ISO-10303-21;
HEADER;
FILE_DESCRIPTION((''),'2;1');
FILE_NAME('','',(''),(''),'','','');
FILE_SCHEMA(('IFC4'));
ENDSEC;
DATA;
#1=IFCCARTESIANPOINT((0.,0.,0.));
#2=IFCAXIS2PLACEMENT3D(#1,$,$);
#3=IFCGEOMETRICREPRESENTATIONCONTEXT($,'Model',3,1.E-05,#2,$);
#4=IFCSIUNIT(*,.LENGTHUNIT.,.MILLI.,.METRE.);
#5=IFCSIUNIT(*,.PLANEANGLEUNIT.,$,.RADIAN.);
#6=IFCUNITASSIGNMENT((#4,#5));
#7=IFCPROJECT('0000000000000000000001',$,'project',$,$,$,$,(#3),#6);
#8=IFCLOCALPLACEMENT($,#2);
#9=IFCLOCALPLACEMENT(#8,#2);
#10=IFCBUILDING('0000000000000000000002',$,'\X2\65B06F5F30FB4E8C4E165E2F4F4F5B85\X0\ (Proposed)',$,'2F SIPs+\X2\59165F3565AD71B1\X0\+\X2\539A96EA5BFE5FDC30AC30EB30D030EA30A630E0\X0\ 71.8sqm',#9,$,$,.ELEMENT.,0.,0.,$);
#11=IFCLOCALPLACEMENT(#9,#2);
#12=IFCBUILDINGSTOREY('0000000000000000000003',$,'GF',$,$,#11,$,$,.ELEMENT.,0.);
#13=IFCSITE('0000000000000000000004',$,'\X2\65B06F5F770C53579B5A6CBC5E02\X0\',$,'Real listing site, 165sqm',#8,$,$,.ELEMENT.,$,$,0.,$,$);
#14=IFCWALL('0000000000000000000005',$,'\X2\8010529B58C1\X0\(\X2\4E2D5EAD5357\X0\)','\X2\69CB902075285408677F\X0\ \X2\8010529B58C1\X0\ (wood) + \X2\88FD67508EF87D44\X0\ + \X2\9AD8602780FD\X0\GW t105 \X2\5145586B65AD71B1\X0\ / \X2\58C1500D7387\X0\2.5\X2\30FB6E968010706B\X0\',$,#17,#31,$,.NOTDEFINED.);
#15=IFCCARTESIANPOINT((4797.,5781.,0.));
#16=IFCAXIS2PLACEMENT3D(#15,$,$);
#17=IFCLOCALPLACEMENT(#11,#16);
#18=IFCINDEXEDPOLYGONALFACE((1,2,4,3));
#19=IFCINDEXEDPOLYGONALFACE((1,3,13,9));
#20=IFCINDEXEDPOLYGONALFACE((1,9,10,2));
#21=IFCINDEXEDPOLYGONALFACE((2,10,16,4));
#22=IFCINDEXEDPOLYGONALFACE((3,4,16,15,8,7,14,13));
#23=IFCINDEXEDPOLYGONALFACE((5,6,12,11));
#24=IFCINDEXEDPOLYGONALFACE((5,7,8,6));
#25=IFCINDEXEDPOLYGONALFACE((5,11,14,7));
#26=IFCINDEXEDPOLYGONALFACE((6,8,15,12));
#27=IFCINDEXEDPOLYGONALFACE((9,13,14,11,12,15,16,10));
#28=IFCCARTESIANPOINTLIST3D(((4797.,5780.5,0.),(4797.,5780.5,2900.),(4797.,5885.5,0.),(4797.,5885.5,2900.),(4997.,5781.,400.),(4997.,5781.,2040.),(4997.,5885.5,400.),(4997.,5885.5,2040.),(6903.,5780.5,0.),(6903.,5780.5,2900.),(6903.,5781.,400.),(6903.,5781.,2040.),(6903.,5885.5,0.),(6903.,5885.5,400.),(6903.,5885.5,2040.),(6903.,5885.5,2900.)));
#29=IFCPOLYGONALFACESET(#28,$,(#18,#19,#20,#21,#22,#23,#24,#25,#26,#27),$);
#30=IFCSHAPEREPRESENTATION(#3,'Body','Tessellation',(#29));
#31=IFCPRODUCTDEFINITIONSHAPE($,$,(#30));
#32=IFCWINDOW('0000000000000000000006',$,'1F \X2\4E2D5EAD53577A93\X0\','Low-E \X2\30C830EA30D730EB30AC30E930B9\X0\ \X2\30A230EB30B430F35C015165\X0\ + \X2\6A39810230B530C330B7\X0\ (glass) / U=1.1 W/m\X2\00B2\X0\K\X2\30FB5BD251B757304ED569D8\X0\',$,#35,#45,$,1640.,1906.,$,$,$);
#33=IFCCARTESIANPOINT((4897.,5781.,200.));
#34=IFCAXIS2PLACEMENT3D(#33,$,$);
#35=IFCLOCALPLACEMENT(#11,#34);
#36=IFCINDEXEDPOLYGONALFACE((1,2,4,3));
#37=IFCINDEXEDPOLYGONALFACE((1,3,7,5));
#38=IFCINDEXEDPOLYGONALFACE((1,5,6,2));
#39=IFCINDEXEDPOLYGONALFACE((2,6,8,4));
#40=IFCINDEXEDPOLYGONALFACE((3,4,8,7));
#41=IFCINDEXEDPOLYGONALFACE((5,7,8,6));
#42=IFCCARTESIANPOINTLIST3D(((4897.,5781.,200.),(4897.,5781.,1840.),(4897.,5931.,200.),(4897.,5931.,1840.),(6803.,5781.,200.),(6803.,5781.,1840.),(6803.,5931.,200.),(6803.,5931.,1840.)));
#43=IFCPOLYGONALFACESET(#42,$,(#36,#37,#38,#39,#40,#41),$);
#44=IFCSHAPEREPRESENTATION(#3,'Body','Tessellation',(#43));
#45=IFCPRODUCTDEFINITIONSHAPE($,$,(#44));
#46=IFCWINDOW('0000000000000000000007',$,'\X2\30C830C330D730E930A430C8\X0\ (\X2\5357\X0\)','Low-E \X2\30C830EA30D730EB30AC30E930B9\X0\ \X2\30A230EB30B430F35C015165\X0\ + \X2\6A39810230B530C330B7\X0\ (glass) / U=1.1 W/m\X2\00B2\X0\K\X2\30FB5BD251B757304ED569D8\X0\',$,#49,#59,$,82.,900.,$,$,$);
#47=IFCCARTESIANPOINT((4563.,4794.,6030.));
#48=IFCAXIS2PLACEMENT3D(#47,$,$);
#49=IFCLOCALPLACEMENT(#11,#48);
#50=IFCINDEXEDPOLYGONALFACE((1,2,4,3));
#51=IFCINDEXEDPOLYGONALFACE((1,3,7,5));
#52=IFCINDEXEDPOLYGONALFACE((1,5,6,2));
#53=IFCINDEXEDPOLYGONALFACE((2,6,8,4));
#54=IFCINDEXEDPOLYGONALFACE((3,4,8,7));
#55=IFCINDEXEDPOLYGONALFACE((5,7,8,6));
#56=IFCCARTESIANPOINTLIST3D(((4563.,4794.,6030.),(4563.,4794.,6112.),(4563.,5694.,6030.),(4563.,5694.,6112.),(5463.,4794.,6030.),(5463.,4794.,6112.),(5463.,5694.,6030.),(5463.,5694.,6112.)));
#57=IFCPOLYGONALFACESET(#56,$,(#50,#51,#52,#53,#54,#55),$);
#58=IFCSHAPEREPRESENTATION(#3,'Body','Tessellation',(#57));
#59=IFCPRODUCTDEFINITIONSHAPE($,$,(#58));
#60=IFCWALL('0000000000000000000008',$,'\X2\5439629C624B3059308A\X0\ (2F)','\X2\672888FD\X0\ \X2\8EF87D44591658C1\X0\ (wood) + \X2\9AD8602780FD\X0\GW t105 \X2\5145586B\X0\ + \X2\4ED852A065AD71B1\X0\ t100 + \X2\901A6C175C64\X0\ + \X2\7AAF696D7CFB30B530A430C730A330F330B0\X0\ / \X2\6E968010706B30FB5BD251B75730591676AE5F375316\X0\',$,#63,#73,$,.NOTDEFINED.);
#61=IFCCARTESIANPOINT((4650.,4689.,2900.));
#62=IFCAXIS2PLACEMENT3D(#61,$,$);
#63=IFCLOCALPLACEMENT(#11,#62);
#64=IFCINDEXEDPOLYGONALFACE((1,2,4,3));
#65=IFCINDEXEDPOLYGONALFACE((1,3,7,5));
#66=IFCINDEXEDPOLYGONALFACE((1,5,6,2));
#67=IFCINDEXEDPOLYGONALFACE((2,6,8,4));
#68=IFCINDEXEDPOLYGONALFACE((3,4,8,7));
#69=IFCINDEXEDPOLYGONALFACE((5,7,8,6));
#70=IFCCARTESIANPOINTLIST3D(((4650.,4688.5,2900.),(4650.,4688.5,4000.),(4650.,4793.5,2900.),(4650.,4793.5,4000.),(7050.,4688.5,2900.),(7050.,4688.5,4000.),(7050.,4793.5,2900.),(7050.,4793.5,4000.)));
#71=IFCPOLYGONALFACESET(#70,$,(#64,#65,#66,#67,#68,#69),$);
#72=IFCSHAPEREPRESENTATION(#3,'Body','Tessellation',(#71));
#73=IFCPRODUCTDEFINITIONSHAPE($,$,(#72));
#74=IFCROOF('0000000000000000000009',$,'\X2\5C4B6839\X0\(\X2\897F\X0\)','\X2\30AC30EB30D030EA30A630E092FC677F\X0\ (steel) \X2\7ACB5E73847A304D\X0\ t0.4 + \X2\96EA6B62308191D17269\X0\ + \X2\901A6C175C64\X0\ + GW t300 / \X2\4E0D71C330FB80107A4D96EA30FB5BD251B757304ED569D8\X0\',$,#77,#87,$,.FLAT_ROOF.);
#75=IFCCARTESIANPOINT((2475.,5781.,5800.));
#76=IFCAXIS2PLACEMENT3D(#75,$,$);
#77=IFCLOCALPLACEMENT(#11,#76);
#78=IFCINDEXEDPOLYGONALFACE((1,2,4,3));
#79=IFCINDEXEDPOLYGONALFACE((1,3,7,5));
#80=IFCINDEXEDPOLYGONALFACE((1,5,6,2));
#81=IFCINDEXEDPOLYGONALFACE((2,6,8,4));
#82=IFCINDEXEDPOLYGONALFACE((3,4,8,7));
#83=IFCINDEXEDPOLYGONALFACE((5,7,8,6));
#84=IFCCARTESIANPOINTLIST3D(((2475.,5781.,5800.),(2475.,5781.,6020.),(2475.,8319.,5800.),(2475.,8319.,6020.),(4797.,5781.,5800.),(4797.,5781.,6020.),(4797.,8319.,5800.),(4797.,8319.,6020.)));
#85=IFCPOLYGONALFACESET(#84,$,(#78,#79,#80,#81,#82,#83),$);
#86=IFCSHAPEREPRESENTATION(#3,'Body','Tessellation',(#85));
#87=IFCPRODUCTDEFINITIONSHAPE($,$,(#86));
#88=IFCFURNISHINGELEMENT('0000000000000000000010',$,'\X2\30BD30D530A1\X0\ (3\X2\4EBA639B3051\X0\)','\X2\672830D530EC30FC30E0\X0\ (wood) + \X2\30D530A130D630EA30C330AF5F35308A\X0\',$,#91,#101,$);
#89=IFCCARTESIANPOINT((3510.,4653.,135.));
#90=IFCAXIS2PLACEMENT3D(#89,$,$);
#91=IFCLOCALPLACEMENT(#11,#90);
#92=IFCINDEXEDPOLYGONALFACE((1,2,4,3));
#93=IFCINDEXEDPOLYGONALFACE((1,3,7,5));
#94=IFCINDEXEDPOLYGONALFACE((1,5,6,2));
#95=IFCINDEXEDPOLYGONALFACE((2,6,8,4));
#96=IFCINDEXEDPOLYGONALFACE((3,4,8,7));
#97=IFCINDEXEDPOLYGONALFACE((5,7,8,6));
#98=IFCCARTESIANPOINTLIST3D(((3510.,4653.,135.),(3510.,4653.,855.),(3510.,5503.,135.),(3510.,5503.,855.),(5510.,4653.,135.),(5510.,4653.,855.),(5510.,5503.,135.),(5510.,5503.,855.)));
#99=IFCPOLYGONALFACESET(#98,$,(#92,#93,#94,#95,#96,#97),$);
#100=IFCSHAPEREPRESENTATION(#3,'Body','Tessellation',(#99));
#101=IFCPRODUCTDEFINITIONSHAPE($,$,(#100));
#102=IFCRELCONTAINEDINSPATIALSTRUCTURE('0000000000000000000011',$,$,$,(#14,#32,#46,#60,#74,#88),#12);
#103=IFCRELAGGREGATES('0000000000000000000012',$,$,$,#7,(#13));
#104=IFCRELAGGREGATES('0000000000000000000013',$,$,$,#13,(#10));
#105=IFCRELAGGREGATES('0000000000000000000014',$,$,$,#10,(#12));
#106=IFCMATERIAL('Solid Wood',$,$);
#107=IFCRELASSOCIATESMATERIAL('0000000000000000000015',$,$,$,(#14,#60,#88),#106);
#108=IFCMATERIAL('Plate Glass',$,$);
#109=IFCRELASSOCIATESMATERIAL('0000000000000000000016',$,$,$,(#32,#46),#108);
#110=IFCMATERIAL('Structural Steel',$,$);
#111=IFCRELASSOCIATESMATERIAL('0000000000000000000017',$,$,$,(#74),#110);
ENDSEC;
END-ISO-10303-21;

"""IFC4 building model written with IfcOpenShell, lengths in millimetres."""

from ifc_helpers import new_model, si_unit, frame, frame_2d, origin, place, context, project, spatial, rectangle, extrude, material, element, fill, save


model = new_model("IFC4")

# Units and contexts
model_context = context("Model", 3, precision=1e-05, world=origin())
ifc_project = project(units=[si_unit("LENGTHUNIT", "METRE", prefix="MILLI"), si_unit("PLANEANGLEUNIT", "RADIAN")], contexts=[model_context])

# Site, building, storey
site_placement = place(None, origin())
site = spatial("IfcSite", under=ifc_project, at=site_placement, Name="新潟県南魚沼市", ObjectType="Real listing site, 165sqm", CompositionType="ELEMENT", RefElevation=0.0)
building_placement = place(site_placement, origin())
building = spatial("IfcBuilding", under=site, at=building_placement, Name="新潟・二世帯住宅 (Proposed)", ObjectType="2F SIPs+外張断熱+厚雪対応ガルバリウム 71.8sqm", CompositionType="ELEMENT", ElevationOfRefHeight=0.0, ElevationOfTerrain=0.0)
storey_placement = place(building_placement, origin())
storey = spatial("IfcBuildingStorey", under=building, at=storey_placement, Name="GF", CompositionType="ELEMENT", Elevation=0.0)

# Shared definitions
ifc_material_1 = material(Name="Solid Wood")

# Wall, opening, window
wall_1_placement = place(storey_placement, frame((4797.0, 5781.0, 0.0)))
wall_1 = element("IfcWall", 1, at=wall_1_placement, inside=storey, material=ifc_material_1, Name="耐力壁(中庭南)", Description="構造用合板 耐力壁 (wood) + 製材軸組 + 高性能GW t105 充填断熱 / 壁倍率2.5・準耐火", PredefinedType="NOTDEFINED", context=model_context, shape_type="SweptSolid", body=[
    extrude(rectangle(XDim=2106.0, YDim=105.0, at=frame_2d((1053.0, 52.0))), frame((4797.0, 5781.0, 0.0)), (0.0, 0.0, 1.0), 2900.0),
])
opening_placement = place(storey_placement, frame((4897.0, 5781.0, 200.0)))
opening = element("IfcOpeningElement", 2, at=opening_placement, cuts=wall_1, PredefinedType="NOTDEFINED", context=model_context, shape_type="SweptSolid", body=[
    extrude(rectangle(XDim=1906.0, YDim=150.0, at=frame_2d((953.0, 75.0))), frame((4897.0, 5781.0, 200.0)), (0.0, 0.0, 1.0), 1640.0),
])
ifc_material_2 = material(Name="Plate Glass")
window_1_placement = place(storey_placement, frame((4897.0, 5781.0, 200.0)))
window_1 = element("IfcWindow", 3, at=window_1_placement, inside=storey, material=ifc_material_2, Name="1F 中庭南窓", Description="Low-E トリプルガラス アルゴン封入 + 樹脂サッシ (glass) / U=1.1 W/m²K・寒冷地仕様", OverallHeight=1640.0, OverallWidth=1906.0, context=model_context, shape_type="SweptSolid", body=[
    extrude(rectangle(XDim=1906.0, YDim=150.0, at=frame_2d((953.0, 75.0))), frame((4897.0, 5781.0, 200.0)), (0.0, 0.0, 1.0), 1640.0),
])
fill(opening, window_1)

# Window
window_2_placement = place(storey_placement, frame((4563.0, 4794.0, 6030.0)))
element("IfcWindow", 4, at=window_2_placement, inside=storey, material=ifc_material_2, Name="トップライト (南)", Description="Low-E トリプルガラス アルゴン封入 + 樹脂サッシ (glass) / U=1.1 W/m²K・寒冷地仕様", OverallHeight=82.0, OverallWidth=900.0, context=model_context, shape_type="SweptSolid", body=[
    extrude(rectangle(XDim=900.0, YDim=900.0, at=frame_2d((450.0, 450.0))), frame((4563.0, 4794.0, 6030.0)), (0.0, 0.0, 1.0), 82.0),
])

# Wall
wall_2_placement = place(storey_placement, frame((4650.0, 4689.0, 2900.0)))
element("IfcWall", 5, at=wall_2_placement, inside=storey, material=ifc_material_1, Name="吹抜手すり (2F)", Description="木製 軸組外壁 (wood) + 高性能GW t105 充填 + 付加断熱 t100 + 通気層 + 窯業系サイディング / 準耐火・寒冷地外皮強化", PredefinedType="NOTDEFINED", context=model_context, shape_type="SweptSolid", body=[
    extrude(rectangle(XDim=2400.0, YDim=105.0, at=frame_2d((1200.0, 52.0))), frame((4650.0, 4689.0, 2900.0)), (0.0, 0.0, 1.0), 1100.0),
])

# Roof
ifc_material_3 = material(Name="Structural Steel")
for number, where, name in (
    (6, (2475.0, 5781.0, 5800.0), "屋根(西)"),
):
    element("IfcRoof", number, at=place(storey_placement, frame(where)), inside=storey, material=ifc_material_3, Name=name, Description="ガルバリウム鋼板 (steel) 立平葺き t0.4 + 雪止め金物 + 通気層 + GW t300 / 不燃・耐積雪・寒冷地仕様", PredefinedType="FLAT_ROOF", context=model_context, shape_type="SweptSolid", body=[
        extrude(rectangle(XDim=2322.0, YDim=2538.0, at=frame_2d((1161.0, 1269.0))), frame((2475.0, 5781.0, 5800.0)), (0.0, 0.0, 1.0), 220.0),
    ])

# Furnishing element
furnishing_placement = place(storey_placement, frame((3510.0, 4653.0, 135.0)))
element("IfcFurnishingElement", 7, at=furnishing_placement, inside=storey, material=ifc_material_1, Name="ソファ (3人掛け)", Description="木フレーム (wood) + ファブリック張り", context=model_context, shape_type="SweptSolid", body=[
    extrude(rectangle(XDim=2000.0, YDim=850.0, at=frame_2d((1000.0, 425.0))), frame((3510.0, 4653.0, 135.0)), (0.0, 0.0, 1.0), 720.0),
])

save(model, "model.ifc")
